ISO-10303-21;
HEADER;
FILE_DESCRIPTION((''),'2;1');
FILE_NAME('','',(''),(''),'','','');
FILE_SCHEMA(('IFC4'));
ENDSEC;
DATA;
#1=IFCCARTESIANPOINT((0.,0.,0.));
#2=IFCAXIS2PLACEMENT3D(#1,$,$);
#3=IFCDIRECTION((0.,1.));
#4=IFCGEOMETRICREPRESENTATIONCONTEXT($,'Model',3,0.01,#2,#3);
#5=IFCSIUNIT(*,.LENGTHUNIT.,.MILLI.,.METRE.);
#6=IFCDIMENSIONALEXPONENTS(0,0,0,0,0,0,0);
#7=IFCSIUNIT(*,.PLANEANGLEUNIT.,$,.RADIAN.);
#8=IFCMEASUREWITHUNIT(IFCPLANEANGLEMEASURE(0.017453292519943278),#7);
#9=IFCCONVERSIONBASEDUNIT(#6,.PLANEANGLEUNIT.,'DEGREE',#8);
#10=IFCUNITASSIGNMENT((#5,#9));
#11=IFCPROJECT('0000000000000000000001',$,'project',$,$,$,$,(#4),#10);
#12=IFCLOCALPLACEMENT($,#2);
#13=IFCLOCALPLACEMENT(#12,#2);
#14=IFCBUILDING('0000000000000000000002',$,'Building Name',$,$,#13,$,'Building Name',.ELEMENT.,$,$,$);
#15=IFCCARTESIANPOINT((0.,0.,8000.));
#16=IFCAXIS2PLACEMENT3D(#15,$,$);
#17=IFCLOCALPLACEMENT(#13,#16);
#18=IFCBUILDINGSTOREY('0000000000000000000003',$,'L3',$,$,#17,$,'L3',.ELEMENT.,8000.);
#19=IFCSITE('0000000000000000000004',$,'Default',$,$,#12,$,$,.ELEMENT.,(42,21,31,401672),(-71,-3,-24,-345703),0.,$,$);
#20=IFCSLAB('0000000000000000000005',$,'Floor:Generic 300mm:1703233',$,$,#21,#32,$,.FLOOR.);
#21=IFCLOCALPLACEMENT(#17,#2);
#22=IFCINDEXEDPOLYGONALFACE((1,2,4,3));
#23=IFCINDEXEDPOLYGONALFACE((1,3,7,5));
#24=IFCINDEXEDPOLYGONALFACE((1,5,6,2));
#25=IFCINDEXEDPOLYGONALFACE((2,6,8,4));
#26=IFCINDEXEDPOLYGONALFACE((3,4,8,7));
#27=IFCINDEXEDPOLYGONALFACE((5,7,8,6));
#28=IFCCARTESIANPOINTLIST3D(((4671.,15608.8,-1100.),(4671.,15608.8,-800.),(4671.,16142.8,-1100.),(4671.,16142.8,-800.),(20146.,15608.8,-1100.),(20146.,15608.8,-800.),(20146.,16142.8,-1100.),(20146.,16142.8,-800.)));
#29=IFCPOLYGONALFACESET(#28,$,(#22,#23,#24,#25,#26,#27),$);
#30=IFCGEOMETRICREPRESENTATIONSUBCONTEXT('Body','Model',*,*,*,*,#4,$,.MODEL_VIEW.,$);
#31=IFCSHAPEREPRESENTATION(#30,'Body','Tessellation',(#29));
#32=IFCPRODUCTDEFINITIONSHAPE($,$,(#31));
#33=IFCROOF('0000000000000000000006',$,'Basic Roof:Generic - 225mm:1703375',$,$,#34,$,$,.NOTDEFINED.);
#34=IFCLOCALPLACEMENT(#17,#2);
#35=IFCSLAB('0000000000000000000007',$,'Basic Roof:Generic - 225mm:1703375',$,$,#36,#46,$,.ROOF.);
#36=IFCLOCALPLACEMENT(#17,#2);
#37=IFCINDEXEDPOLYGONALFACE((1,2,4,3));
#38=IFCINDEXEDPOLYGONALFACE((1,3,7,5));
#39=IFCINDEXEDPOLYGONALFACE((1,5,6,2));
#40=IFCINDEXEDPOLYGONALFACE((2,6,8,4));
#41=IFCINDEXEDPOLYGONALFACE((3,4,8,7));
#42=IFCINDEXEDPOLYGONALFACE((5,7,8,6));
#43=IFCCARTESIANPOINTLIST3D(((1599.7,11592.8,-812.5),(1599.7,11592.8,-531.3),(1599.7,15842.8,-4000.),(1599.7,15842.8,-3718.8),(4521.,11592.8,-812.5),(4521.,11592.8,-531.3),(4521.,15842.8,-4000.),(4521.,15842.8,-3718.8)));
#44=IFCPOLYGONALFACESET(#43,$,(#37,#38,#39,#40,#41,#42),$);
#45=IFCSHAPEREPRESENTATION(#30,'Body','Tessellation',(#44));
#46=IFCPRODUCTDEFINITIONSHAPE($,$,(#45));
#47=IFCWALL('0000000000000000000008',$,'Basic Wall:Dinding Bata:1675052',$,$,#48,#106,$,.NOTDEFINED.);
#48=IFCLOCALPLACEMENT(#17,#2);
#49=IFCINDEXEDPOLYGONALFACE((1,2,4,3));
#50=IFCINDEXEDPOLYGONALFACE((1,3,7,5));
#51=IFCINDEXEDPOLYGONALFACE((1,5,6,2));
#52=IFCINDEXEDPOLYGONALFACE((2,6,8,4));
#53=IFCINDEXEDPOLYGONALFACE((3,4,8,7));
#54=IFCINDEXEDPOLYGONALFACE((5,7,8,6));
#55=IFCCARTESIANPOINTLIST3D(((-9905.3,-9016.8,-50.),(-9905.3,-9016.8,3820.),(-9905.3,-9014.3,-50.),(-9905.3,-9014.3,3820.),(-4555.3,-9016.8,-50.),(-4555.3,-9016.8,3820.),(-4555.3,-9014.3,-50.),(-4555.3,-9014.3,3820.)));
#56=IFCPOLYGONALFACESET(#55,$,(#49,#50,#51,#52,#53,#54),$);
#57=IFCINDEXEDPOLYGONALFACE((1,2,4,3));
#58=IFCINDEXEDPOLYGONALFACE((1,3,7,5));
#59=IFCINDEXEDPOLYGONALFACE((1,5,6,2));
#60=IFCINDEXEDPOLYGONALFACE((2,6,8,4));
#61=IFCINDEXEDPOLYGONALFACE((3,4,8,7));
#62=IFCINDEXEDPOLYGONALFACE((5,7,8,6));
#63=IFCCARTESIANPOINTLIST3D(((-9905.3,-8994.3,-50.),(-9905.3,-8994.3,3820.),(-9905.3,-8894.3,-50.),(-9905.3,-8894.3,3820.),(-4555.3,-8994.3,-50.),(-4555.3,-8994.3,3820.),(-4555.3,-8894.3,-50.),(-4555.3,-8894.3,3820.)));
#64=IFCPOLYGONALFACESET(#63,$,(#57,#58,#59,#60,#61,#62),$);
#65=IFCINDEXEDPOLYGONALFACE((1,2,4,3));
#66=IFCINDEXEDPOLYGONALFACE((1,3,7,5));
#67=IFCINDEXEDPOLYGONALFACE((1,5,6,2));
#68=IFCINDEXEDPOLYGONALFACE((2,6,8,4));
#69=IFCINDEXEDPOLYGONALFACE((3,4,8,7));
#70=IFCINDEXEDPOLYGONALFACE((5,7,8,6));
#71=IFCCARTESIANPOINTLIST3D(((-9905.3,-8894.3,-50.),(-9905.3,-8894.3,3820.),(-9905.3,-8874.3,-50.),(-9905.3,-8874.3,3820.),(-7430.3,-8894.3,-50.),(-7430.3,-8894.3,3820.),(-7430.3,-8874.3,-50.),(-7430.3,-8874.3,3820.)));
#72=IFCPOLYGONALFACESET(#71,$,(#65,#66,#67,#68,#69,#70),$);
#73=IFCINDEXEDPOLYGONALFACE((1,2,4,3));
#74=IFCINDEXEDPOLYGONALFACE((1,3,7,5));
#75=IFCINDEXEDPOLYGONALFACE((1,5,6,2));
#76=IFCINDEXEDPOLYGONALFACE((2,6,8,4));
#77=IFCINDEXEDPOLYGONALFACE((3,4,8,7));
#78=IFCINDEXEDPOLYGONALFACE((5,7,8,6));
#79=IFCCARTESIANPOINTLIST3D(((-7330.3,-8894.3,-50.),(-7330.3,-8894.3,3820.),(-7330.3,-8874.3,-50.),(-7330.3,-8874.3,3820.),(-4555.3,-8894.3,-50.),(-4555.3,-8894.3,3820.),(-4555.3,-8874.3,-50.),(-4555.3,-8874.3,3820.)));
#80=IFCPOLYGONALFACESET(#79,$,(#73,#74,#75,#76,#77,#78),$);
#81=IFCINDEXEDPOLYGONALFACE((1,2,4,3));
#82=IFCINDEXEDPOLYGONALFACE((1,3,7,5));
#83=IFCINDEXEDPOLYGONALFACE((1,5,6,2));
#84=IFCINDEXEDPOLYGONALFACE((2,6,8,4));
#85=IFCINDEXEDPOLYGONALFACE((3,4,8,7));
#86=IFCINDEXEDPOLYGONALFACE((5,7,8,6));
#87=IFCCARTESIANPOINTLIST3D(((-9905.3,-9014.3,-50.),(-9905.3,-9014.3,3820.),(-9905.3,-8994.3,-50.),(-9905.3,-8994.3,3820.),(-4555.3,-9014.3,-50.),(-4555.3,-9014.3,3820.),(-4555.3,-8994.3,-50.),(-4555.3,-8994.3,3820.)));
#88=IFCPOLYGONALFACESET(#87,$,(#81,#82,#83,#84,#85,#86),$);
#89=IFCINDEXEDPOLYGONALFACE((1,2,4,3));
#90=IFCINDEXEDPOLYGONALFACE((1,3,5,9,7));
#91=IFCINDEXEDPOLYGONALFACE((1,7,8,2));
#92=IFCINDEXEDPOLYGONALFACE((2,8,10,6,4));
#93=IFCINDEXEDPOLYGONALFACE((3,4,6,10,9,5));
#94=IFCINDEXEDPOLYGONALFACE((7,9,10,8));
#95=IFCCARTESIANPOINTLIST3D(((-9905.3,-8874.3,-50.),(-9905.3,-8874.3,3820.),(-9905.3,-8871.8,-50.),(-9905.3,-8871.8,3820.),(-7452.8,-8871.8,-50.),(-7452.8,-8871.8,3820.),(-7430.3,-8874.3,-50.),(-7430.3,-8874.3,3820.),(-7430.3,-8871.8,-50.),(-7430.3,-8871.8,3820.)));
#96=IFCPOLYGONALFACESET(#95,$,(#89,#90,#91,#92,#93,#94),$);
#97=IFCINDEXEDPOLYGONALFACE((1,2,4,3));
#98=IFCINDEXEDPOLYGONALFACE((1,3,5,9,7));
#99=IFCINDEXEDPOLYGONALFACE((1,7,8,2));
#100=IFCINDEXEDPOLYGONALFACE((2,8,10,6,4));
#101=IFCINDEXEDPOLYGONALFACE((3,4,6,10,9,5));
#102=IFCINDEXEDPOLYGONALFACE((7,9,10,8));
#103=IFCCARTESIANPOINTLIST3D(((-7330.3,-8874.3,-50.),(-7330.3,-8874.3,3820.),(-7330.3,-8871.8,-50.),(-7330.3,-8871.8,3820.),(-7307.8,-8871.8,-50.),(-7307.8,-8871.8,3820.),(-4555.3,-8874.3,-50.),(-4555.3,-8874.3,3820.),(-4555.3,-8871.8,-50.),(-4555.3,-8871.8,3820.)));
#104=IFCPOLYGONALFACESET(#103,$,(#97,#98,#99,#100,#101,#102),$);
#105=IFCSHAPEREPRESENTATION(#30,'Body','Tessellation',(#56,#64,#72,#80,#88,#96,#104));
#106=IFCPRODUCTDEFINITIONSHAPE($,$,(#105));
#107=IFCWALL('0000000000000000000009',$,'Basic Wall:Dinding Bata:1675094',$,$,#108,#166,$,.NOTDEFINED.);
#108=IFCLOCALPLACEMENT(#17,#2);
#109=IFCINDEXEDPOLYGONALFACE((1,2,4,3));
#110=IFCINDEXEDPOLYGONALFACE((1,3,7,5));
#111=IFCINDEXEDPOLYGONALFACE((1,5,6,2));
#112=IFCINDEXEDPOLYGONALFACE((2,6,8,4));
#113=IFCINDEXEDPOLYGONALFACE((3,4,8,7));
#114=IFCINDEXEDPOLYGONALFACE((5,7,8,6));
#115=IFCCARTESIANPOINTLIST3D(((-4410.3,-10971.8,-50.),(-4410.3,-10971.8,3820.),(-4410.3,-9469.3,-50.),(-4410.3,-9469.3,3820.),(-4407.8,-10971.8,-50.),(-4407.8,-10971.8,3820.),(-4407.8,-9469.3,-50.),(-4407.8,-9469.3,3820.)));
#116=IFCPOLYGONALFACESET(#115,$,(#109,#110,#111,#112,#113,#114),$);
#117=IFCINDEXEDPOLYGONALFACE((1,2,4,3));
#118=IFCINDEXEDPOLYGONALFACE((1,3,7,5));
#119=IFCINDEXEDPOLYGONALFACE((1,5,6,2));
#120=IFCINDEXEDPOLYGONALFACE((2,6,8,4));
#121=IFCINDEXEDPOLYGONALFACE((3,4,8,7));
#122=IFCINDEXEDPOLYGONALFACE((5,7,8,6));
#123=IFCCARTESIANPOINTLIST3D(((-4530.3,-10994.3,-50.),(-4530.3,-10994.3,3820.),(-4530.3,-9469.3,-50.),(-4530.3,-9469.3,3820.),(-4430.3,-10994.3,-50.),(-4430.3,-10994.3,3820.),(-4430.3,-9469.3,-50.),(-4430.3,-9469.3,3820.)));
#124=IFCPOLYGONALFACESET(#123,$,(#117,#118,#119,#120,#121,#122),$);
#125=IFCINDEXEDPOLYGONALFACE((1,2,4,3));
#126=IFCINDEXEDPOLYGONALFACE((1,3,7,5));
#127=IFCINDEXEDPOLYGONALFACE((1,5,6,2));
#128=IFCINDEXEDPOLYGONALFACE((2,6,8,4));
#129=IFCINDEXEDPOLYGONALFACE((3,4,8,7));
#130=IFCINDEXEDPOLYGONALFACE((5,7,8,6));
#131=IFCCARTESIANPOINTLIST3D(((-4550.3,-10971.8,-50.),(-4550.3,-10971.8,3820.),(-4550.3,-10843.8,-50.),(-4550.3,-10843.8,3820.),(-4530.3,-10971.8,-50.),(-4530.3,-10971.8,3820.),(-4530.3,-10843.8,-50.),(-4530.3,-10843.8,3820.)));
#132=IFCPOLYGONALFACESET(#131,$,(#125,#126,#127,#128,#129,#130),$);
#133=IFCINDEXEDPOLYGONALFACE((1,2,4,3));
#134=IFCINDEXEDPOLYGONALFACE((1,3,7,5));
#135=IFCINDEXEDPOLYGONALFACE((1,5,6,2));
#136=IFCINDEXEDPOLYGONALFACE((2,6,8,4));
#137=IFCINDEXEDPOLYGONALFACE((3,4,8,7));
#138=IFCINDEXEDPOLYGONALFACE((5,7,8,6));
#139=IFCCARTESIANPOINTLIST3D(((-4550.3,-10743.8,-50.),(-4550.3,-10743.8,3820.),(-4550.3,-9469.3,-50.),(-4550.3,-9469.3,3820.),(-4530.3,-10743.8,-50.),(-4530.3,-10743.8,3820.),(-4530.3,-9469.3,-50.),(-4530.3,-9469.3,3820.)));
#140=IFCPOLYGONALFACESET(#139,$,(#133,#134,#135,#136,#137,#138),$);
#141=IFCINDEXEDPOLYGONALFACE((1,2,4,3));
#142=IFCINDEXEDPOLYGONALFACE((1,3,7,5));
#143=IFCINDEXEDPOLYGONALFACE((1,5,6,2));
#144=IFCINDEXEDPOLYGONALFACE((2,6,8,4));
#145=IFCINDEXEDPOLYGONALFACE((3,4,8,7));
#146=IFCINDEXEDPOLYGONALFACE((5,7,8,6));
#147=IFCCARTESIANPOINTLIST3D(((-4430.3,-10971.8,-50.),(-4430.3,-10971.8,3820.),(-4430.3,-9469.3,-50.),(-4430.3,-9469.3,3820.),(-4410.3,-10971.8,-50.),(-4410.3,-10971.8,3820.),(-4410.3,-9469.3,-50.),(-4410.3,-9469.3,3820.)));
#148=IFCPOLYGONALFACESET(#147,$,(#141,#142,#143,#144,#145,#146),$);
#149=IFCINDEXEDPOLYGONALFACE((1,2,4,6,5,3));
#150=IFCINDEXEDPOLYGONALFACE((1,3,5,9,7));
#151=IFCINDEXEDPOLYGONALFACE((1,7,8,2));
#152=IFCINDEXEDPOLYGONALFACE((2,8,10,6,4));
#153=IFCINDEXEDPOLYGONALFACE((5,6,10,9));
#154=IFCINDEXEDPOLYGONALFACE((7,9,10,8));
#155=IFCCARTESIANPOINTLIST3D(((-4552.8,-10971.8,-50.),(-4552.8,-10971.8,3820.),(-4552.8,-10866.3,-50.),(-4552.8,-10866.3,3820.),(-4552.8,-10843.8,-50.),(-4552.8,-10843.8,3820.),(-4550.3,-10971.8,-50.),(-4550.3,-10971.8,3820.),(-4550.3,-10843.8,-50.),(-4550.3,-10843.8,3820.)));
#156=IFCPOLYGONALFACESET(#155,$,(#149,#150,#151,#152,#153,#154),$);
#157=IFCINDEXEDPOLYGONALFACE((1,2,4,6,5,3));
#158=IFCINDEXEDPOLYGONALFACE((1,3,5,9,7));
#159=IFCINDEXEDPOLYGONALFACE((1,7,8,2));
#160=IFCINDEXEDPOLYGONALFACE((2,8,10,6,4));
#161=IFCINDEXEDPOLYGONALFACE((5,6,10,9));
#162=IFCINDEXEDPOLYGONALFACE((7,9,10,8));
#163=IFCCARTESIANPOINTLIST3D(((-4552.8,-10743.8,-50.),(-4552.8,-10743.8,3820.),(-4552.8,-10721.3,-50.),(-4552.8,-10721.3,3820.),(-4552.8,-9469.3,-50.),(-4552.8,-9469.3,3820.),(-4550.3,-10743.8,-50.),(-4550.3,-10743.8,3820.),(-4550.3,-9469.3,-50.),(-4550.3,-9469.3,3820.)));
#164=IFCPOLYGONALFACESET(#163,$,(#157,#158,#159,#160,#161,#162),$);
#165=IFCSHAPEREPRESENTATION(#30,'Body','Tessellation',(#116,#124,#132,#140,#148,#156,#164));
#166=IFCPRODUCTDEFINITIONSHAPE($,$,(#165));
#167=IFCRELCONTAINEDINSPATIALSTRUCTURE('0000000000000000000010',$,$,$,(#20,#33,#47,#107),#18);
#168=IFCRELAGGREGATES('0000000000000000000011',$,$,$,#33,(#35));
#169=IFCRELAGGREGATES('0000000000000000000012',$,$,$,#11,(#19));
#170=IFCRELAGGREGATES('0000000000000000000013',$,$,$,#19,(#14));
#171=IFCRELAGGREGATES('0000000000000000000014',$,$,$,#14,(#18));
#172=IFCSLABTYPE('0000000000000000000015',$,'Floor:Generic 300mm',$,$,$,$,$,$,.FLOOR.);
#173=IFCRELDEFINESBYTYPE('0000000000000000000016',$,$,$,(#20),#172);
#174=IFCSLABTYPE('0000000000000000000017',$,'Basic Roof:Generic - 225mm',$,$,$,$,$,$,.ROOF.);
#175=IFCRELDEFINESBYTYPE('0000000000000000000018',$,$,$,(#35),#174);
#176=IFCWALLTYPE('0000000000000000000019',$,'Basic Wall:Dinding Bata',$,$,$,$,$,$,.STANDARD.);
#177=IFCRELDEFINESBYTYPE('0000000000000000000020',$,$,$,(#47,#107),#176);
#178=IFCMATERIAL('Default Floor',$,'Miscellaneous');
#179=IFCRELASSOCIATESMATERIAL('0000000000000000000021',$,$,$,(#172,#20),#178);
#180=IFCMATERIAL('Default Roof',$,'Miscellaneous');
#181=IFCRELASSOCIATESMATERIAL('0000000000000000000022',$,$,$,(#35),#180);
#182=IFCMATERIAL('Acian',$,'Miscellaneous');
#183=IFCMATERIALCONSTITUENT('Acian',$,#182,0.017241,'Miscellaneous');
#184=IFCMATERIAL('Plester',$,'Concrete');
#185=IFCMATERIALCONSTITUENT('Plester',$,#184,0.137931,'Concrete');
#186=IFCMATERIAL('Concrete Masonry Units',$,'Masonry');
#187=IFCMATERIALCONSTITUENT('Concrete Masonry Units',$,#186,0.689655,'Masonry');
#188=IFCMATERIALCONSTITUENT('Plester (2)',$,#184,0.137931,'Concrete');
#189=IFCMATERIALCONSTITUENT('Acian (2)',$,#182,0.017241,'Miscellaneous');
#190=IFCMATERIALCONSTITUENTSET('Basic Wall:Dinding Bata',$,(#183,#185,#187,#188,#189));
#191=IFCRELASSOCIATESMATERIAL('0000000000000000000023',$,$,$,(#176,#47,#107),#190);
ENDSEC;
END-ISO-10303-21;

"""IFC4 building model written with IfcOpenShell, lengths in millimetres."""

from ifc_helpers import new_model, entity, si_unit, converted_unit, direction, frame, origin, place, context, subcontext, project, spatial, indexed_curve, outline, extrude, material, constituent, constituent_set, type_object, element, aggregate, save


model = new_model("IFC4")

# Units and contexts
model_context = context("Model", 3, precision=0.01, world=origin(), true_north=direction((0.0, 1.0)))
body_context = subcontext(model_context, "Body", "Model", "MODEL_VIEW")
ifc_project = project(units=[si_unit("LENGTHUNIT", "METRE", prefix="MILLI"), converted_unit("PLANEANGLEUNIT", "DEGREE", entity("IfcPlaneAngleMeasure", 0.017453292519943278), si_unit("PLANEANGLEUNIT", "RADIAN"), dimensions=[0, 0, 0, 0, 0, 0, 0])], contexts=[model_context])

# Site, building, storey
site_placement = place(None, origin())
site = spatial("IfcSite", under=ifc_project, at=site_placement, Name="Default", CompositionType="ELEMENT", RefLatitude=(42, 21, 31, 401672), RefLongitude=(-71, -3, -24, -345703), RefElevation=0.0)
building_placement = place(site_placement, origin())
building = spatial("IfcBuilding", under=site, at=building_placement, Name="Building Name", LongName="Building Name", CompositionType="ELEMENT")
storey_placement = place(building_placement, frame((0.0, 0.0, 8000.0)))
storey = spatial("IfcBuildingStorey", under=building, at=storey_placement, Name="L3", LongName="L3", CompositionType="ELEMENT", Elevation=8000.0)

# Slab
ifc_material_1 = material(Name="Default Floor", Category="Miscellaneous")
slab_type_1 = type_object("IfcSlabType", Name="Floor:Generic 300mm", PredefinedType="FLOOR", material=ifc_material_1)
slab_1_placement = place(storey_placement, origin())
element("IfcSlab", 1, at=slab_1_placement, inside=storey, type_object=slab_type_1, material=ifc_material_1, Name="Floor:Generic 300mm:1703233", PredefinedType="FLOOR", context=body_context, shape_type="SweptSolid", body=[
    extrude(outline(indexed_curve([(-267.0, -7737.5), (267.0, -7737.5), (267.0, 7737.5), (-267.0, 7737.5), (-267.0, -7737.5)], self_intersect=False)), frame((12408.5, 15875.8, -800.0), z_axis=(0.0, 0.0, -1.0), x_axis=(0.0, 1.0, 0.0)), (0.0, 0.0, 1.0), 300.0),
])

# Roof, slab
roof_placement = place(storey_placement, frame((1599.7, 11592.8, -4000.0)))
roof = element("IfcRoof", 2, at=roof_placement, inside=storey, Name="Basic Roof:Generic - 225mm:1703375", PredefinedType="NOTDEFINED")
ifc_material_2 = material(Name="Default Roof", Category="Miscellaneous")
slab_type_2 = type_object("IfcSlabType", Name="Basic Roof:Generic - 225mm", PredefinedType="ROOF")
slab_2_placement = place(roof_placement, origin())
slab_2 = element("IfcSlab", 3, at=slab_2_placement, type_object=slab_type_2, material=ifc_material_2, Name="Basic Roof:Generic - 225mm:1703375", PredefinedType="ROOF", context=body_context, shape_type="SweptSolid", body=[
    extrude(outline(indexed_curve([(-1460.6, -2656.2), (1460.6, -2656.2), (1460.6, 2656.2), (-1460.6, 2656.2), (-1460.6, -2656.2)], self_intersect=False)), frame((1460.6, 2125.0, 1593.7), z_axis=(0.0, 0.6, 0.8), x_axis=(1.0, 0.0, 0.0)), (0.0, -0.6, 0.8), 281.2),
])
aggregate(roof, [slab_2])

# Walls
ifc_material_3 = material(Name="Acian", Category="Miscellaneous")
ifc_constituent_1 = constituent(ifc_material_3, Name="Acian", Category="Miscellaneous", fraction=0.017241)
ifc_material_4 = material(Name="Plester", Category="Concrete")
ifc_constituent_2 = constituent(ifc_material_4, Name="Plester", Category="Concrete", fraction=0.137931)
ifc_material_5 = material(Name="Concrete Masonry Units", Category="Masonry")
ifc_constituent_3 = constituent(ifc_material_5, Name="Concrete Masonry Units", Category="Masonry", fraction=0.689655)
ifc_constituent_4 = constituent(ifc_material_4, Name="Plester (2)", Category="Concrete", fraction=0.137931)
ifc_constituent_5 = constituent(ifc_material_3, Name="Acian (2)", Category="Miscellaneous", fraction=0.017241)
ifc_constituent_set = constituent_set(constituents=[ifc_constituent_1, ifc_constituent_2, ifc_constituent_3, ifc_constituent_4, ifc_constituent_5], Name="Basic Wall:Dinding Bata")
wall_type = type_object("IfcWallType", Name="Basic Wall:Dinding Bata", PredefinedType="STANDARD", material=ifc_constituent_set)
wall_1_placement = place(storey_placement, frame((-4555.3, -8944.3, -50.0), z_axis=(0.0, 0.0, 1.0), x_axis=(-1.0, 0.0, 0.0)))
element("IfcWall", 4, at=wall_1_placement, inside=storey, type_object=wall_type, material=ifc_constituent_set, Name="Basic Wall:Dinding Bata:1675052", PredefinedType="NOTDEFINED", context=body_context, shape_type="SweptSolid", body=[
    extrude(outline(indexed_curve([(-1.3, -2675.0), (1.2, -2675.0), (1.3, 2675.0), (-1.2, 2675.0), (-1.3, -2675.0)], self_intersect=False)), frame((2675.0, 71.2, 0.0), z_axis=(0.0, 0.0, 1.0), x_axis=(0.0, -1.0, 0.0)), (0.0, 0.0, 1.0), 3870.0),
    extrude(outline(indexed_curve([(-2675.0, -50.0), (2675.0, -50.0), (2675.0, 50.0), (-2675.0, 50.0), (-2675.0, -50.0)], self_intersect=False)), frame((2675.0, 0.0, 0.0)), (0.0, 0.0, 1.0), 3870.0),
    extrude(outline(indexed_curve([(-1237.5, -10.0), (1237.5, -10.0), (1237.5, 10.0), (-1237.5, 10.0), (-1237.5, -10.0)], self_intersect=False)), frame((4112.5, -60.0, 0.0), z_axis=(0.0, 0.0, 1.0), x_axis=(-1.0, 0.0, 0.0)), (0.0, 0.0, 1.0), 3870.0),
    extrude(outline(indexed_curve([(-1387.5, -10.0), (1387.5, -10.0), (1387.5, 10.0), (-1387.5, 10.0), (-1387.5, -10.0)], self_intersect=False)), frame((1387.5, -60.0, 0.0)), (0.0, 0.0, 1.0), 3870.0),
    extrude(outline(indexed_curve([(-2675.0, -10.0), (2675.0, -10.0), (2675.0, 10.0), (-2675.0, 10.0), (-2675.0, -10.0)], self_intersect=False)), frame((2675.0, 60.0, 0.0)), (0.0, 0.0, 1.0), 3870.0),
    extrude(outline(indexed_curve([(-1.0, -1480.5), (1.5, -1480.5), (1.5, 994.5), (-1.0, 994.5), (-1.0, 972.0), (-1.0, -1480.5)], self_intersect=False)), frame((3869.5, -71.5, 0.0), z_axis=(0.0, 0.0, 1.0), x_axis=(0.0, 1.0, 0.0)), (0.0, 0.0, 1.0), 3870.0),
    extrude(outline(indexed_curve([(1092.0, -1.0), (1114.5, -1.0), (1114.5, 1.5), (-1660.5, 1.5), (-1660.5, -1.0), (1092.0, -1.0)], self_intersect=False)), frame((1660.5, -71.5, 0.0)), (0.0, 0.0, 1.0), 3870.0),
])
wall_2_placement = place(storey_placement, frame((-4480.3, -9469.3, -50.0), z_axis=(0.0, 0.0, 1.0), x_axis=(0.0, -1.0, 0.0)))
element("IfcWall", 5, at=wall_2_placement, inside=storey, type_object=wall_type, material=ifc_constituent_set, Name="Basic Wall:Dinding Bata:1675094", PredefinedType="NOTDEFINED", context=body_context, shape_type="SweptSolid", body=[
    extrude(outline(indexed_curve([(-1.3, -751.2), (1.2, -751.2), (1.3, 751.2), (-1.2, 751.2), (-1.3, -751.2)], self_intersect=False)), frame((751.2, 71.3, 0.0), z_axis=(0.0, 0.0, 1.0), x_axis=(0.0, -1.0, 0.0)), (0.0, 0.0, 1.0), 3870.0),
    extrude(outline(indexed_curve([(-762.5, -50.0), (762.5, -50.0), (762.5, 50.0), (-762.5, 50.0), (-762.5, -50.0)], self_intersect=False)), frame((762.5, 0.0, 0.0)), (0.0, 0.0, 1.0), 3870.0),
    extrude(outline(indexed_curve([(-64.0, -10.0), (64.0, -10.0), (64.0, 10.0), (-64.0, 10.0), (-64.0, -10.0)], self_intersect=False)), frame((1438.5, -60.0, 0.0), z_axis=(0.0, 0.0, 1.0), x_axis=(-1.0, 0.0, 0.0)), (0.0, 0.0, 1.0), 3870.0),
    extrude(outline(indexed_curve([(-637.2, -10.0), (637.2, -10.0), (637.2, 10.0), (-637.2, 10.0), (-637.2, -10.0)], self_intersect=False)), frame((637.2, -60.0, 0.0)), (0.0, 0.0, 1.0), 3870.0),
    extrude(outline(indexed_curve([(-751.2, -10.0), (751.2, -10.0), (751.2, 10.0), (-751.2, 10.0), (-751.2, -10.0)], self_intersect=False)), frame((751.2, 60.0, 0.0)), (0.0, 0.0, 1.0), 3870.0),
    extrude(outline(indexed_curve([(-1.0, -72.3), (1.5, -72.3), (1.5, 55.7), (-1.0, 55.7), (-1.0, 33.2), (-1.0, -72.3)], self_intersect=False)), frame((1430.2, -71.5, 0.0), z_axis=(0.0, 0.0, 1.0), x_axis=(0.0, 1.0, 0.0)), (0.0, 0.0, 1.0), 3870.0),
    extrude(outline(indexed_curve([(491.8, -1.0), (514.3, -1.0), (514.3, 1.5), (-760.2, 1.5), (-760.2, -1.0), (491.8, -1.0)], self_intersect=False)), frame((760.2, -71.5, 0.0)), (0.0, 0.0, 1.0), 3870.0),
])

save(model, "model.ifc")
